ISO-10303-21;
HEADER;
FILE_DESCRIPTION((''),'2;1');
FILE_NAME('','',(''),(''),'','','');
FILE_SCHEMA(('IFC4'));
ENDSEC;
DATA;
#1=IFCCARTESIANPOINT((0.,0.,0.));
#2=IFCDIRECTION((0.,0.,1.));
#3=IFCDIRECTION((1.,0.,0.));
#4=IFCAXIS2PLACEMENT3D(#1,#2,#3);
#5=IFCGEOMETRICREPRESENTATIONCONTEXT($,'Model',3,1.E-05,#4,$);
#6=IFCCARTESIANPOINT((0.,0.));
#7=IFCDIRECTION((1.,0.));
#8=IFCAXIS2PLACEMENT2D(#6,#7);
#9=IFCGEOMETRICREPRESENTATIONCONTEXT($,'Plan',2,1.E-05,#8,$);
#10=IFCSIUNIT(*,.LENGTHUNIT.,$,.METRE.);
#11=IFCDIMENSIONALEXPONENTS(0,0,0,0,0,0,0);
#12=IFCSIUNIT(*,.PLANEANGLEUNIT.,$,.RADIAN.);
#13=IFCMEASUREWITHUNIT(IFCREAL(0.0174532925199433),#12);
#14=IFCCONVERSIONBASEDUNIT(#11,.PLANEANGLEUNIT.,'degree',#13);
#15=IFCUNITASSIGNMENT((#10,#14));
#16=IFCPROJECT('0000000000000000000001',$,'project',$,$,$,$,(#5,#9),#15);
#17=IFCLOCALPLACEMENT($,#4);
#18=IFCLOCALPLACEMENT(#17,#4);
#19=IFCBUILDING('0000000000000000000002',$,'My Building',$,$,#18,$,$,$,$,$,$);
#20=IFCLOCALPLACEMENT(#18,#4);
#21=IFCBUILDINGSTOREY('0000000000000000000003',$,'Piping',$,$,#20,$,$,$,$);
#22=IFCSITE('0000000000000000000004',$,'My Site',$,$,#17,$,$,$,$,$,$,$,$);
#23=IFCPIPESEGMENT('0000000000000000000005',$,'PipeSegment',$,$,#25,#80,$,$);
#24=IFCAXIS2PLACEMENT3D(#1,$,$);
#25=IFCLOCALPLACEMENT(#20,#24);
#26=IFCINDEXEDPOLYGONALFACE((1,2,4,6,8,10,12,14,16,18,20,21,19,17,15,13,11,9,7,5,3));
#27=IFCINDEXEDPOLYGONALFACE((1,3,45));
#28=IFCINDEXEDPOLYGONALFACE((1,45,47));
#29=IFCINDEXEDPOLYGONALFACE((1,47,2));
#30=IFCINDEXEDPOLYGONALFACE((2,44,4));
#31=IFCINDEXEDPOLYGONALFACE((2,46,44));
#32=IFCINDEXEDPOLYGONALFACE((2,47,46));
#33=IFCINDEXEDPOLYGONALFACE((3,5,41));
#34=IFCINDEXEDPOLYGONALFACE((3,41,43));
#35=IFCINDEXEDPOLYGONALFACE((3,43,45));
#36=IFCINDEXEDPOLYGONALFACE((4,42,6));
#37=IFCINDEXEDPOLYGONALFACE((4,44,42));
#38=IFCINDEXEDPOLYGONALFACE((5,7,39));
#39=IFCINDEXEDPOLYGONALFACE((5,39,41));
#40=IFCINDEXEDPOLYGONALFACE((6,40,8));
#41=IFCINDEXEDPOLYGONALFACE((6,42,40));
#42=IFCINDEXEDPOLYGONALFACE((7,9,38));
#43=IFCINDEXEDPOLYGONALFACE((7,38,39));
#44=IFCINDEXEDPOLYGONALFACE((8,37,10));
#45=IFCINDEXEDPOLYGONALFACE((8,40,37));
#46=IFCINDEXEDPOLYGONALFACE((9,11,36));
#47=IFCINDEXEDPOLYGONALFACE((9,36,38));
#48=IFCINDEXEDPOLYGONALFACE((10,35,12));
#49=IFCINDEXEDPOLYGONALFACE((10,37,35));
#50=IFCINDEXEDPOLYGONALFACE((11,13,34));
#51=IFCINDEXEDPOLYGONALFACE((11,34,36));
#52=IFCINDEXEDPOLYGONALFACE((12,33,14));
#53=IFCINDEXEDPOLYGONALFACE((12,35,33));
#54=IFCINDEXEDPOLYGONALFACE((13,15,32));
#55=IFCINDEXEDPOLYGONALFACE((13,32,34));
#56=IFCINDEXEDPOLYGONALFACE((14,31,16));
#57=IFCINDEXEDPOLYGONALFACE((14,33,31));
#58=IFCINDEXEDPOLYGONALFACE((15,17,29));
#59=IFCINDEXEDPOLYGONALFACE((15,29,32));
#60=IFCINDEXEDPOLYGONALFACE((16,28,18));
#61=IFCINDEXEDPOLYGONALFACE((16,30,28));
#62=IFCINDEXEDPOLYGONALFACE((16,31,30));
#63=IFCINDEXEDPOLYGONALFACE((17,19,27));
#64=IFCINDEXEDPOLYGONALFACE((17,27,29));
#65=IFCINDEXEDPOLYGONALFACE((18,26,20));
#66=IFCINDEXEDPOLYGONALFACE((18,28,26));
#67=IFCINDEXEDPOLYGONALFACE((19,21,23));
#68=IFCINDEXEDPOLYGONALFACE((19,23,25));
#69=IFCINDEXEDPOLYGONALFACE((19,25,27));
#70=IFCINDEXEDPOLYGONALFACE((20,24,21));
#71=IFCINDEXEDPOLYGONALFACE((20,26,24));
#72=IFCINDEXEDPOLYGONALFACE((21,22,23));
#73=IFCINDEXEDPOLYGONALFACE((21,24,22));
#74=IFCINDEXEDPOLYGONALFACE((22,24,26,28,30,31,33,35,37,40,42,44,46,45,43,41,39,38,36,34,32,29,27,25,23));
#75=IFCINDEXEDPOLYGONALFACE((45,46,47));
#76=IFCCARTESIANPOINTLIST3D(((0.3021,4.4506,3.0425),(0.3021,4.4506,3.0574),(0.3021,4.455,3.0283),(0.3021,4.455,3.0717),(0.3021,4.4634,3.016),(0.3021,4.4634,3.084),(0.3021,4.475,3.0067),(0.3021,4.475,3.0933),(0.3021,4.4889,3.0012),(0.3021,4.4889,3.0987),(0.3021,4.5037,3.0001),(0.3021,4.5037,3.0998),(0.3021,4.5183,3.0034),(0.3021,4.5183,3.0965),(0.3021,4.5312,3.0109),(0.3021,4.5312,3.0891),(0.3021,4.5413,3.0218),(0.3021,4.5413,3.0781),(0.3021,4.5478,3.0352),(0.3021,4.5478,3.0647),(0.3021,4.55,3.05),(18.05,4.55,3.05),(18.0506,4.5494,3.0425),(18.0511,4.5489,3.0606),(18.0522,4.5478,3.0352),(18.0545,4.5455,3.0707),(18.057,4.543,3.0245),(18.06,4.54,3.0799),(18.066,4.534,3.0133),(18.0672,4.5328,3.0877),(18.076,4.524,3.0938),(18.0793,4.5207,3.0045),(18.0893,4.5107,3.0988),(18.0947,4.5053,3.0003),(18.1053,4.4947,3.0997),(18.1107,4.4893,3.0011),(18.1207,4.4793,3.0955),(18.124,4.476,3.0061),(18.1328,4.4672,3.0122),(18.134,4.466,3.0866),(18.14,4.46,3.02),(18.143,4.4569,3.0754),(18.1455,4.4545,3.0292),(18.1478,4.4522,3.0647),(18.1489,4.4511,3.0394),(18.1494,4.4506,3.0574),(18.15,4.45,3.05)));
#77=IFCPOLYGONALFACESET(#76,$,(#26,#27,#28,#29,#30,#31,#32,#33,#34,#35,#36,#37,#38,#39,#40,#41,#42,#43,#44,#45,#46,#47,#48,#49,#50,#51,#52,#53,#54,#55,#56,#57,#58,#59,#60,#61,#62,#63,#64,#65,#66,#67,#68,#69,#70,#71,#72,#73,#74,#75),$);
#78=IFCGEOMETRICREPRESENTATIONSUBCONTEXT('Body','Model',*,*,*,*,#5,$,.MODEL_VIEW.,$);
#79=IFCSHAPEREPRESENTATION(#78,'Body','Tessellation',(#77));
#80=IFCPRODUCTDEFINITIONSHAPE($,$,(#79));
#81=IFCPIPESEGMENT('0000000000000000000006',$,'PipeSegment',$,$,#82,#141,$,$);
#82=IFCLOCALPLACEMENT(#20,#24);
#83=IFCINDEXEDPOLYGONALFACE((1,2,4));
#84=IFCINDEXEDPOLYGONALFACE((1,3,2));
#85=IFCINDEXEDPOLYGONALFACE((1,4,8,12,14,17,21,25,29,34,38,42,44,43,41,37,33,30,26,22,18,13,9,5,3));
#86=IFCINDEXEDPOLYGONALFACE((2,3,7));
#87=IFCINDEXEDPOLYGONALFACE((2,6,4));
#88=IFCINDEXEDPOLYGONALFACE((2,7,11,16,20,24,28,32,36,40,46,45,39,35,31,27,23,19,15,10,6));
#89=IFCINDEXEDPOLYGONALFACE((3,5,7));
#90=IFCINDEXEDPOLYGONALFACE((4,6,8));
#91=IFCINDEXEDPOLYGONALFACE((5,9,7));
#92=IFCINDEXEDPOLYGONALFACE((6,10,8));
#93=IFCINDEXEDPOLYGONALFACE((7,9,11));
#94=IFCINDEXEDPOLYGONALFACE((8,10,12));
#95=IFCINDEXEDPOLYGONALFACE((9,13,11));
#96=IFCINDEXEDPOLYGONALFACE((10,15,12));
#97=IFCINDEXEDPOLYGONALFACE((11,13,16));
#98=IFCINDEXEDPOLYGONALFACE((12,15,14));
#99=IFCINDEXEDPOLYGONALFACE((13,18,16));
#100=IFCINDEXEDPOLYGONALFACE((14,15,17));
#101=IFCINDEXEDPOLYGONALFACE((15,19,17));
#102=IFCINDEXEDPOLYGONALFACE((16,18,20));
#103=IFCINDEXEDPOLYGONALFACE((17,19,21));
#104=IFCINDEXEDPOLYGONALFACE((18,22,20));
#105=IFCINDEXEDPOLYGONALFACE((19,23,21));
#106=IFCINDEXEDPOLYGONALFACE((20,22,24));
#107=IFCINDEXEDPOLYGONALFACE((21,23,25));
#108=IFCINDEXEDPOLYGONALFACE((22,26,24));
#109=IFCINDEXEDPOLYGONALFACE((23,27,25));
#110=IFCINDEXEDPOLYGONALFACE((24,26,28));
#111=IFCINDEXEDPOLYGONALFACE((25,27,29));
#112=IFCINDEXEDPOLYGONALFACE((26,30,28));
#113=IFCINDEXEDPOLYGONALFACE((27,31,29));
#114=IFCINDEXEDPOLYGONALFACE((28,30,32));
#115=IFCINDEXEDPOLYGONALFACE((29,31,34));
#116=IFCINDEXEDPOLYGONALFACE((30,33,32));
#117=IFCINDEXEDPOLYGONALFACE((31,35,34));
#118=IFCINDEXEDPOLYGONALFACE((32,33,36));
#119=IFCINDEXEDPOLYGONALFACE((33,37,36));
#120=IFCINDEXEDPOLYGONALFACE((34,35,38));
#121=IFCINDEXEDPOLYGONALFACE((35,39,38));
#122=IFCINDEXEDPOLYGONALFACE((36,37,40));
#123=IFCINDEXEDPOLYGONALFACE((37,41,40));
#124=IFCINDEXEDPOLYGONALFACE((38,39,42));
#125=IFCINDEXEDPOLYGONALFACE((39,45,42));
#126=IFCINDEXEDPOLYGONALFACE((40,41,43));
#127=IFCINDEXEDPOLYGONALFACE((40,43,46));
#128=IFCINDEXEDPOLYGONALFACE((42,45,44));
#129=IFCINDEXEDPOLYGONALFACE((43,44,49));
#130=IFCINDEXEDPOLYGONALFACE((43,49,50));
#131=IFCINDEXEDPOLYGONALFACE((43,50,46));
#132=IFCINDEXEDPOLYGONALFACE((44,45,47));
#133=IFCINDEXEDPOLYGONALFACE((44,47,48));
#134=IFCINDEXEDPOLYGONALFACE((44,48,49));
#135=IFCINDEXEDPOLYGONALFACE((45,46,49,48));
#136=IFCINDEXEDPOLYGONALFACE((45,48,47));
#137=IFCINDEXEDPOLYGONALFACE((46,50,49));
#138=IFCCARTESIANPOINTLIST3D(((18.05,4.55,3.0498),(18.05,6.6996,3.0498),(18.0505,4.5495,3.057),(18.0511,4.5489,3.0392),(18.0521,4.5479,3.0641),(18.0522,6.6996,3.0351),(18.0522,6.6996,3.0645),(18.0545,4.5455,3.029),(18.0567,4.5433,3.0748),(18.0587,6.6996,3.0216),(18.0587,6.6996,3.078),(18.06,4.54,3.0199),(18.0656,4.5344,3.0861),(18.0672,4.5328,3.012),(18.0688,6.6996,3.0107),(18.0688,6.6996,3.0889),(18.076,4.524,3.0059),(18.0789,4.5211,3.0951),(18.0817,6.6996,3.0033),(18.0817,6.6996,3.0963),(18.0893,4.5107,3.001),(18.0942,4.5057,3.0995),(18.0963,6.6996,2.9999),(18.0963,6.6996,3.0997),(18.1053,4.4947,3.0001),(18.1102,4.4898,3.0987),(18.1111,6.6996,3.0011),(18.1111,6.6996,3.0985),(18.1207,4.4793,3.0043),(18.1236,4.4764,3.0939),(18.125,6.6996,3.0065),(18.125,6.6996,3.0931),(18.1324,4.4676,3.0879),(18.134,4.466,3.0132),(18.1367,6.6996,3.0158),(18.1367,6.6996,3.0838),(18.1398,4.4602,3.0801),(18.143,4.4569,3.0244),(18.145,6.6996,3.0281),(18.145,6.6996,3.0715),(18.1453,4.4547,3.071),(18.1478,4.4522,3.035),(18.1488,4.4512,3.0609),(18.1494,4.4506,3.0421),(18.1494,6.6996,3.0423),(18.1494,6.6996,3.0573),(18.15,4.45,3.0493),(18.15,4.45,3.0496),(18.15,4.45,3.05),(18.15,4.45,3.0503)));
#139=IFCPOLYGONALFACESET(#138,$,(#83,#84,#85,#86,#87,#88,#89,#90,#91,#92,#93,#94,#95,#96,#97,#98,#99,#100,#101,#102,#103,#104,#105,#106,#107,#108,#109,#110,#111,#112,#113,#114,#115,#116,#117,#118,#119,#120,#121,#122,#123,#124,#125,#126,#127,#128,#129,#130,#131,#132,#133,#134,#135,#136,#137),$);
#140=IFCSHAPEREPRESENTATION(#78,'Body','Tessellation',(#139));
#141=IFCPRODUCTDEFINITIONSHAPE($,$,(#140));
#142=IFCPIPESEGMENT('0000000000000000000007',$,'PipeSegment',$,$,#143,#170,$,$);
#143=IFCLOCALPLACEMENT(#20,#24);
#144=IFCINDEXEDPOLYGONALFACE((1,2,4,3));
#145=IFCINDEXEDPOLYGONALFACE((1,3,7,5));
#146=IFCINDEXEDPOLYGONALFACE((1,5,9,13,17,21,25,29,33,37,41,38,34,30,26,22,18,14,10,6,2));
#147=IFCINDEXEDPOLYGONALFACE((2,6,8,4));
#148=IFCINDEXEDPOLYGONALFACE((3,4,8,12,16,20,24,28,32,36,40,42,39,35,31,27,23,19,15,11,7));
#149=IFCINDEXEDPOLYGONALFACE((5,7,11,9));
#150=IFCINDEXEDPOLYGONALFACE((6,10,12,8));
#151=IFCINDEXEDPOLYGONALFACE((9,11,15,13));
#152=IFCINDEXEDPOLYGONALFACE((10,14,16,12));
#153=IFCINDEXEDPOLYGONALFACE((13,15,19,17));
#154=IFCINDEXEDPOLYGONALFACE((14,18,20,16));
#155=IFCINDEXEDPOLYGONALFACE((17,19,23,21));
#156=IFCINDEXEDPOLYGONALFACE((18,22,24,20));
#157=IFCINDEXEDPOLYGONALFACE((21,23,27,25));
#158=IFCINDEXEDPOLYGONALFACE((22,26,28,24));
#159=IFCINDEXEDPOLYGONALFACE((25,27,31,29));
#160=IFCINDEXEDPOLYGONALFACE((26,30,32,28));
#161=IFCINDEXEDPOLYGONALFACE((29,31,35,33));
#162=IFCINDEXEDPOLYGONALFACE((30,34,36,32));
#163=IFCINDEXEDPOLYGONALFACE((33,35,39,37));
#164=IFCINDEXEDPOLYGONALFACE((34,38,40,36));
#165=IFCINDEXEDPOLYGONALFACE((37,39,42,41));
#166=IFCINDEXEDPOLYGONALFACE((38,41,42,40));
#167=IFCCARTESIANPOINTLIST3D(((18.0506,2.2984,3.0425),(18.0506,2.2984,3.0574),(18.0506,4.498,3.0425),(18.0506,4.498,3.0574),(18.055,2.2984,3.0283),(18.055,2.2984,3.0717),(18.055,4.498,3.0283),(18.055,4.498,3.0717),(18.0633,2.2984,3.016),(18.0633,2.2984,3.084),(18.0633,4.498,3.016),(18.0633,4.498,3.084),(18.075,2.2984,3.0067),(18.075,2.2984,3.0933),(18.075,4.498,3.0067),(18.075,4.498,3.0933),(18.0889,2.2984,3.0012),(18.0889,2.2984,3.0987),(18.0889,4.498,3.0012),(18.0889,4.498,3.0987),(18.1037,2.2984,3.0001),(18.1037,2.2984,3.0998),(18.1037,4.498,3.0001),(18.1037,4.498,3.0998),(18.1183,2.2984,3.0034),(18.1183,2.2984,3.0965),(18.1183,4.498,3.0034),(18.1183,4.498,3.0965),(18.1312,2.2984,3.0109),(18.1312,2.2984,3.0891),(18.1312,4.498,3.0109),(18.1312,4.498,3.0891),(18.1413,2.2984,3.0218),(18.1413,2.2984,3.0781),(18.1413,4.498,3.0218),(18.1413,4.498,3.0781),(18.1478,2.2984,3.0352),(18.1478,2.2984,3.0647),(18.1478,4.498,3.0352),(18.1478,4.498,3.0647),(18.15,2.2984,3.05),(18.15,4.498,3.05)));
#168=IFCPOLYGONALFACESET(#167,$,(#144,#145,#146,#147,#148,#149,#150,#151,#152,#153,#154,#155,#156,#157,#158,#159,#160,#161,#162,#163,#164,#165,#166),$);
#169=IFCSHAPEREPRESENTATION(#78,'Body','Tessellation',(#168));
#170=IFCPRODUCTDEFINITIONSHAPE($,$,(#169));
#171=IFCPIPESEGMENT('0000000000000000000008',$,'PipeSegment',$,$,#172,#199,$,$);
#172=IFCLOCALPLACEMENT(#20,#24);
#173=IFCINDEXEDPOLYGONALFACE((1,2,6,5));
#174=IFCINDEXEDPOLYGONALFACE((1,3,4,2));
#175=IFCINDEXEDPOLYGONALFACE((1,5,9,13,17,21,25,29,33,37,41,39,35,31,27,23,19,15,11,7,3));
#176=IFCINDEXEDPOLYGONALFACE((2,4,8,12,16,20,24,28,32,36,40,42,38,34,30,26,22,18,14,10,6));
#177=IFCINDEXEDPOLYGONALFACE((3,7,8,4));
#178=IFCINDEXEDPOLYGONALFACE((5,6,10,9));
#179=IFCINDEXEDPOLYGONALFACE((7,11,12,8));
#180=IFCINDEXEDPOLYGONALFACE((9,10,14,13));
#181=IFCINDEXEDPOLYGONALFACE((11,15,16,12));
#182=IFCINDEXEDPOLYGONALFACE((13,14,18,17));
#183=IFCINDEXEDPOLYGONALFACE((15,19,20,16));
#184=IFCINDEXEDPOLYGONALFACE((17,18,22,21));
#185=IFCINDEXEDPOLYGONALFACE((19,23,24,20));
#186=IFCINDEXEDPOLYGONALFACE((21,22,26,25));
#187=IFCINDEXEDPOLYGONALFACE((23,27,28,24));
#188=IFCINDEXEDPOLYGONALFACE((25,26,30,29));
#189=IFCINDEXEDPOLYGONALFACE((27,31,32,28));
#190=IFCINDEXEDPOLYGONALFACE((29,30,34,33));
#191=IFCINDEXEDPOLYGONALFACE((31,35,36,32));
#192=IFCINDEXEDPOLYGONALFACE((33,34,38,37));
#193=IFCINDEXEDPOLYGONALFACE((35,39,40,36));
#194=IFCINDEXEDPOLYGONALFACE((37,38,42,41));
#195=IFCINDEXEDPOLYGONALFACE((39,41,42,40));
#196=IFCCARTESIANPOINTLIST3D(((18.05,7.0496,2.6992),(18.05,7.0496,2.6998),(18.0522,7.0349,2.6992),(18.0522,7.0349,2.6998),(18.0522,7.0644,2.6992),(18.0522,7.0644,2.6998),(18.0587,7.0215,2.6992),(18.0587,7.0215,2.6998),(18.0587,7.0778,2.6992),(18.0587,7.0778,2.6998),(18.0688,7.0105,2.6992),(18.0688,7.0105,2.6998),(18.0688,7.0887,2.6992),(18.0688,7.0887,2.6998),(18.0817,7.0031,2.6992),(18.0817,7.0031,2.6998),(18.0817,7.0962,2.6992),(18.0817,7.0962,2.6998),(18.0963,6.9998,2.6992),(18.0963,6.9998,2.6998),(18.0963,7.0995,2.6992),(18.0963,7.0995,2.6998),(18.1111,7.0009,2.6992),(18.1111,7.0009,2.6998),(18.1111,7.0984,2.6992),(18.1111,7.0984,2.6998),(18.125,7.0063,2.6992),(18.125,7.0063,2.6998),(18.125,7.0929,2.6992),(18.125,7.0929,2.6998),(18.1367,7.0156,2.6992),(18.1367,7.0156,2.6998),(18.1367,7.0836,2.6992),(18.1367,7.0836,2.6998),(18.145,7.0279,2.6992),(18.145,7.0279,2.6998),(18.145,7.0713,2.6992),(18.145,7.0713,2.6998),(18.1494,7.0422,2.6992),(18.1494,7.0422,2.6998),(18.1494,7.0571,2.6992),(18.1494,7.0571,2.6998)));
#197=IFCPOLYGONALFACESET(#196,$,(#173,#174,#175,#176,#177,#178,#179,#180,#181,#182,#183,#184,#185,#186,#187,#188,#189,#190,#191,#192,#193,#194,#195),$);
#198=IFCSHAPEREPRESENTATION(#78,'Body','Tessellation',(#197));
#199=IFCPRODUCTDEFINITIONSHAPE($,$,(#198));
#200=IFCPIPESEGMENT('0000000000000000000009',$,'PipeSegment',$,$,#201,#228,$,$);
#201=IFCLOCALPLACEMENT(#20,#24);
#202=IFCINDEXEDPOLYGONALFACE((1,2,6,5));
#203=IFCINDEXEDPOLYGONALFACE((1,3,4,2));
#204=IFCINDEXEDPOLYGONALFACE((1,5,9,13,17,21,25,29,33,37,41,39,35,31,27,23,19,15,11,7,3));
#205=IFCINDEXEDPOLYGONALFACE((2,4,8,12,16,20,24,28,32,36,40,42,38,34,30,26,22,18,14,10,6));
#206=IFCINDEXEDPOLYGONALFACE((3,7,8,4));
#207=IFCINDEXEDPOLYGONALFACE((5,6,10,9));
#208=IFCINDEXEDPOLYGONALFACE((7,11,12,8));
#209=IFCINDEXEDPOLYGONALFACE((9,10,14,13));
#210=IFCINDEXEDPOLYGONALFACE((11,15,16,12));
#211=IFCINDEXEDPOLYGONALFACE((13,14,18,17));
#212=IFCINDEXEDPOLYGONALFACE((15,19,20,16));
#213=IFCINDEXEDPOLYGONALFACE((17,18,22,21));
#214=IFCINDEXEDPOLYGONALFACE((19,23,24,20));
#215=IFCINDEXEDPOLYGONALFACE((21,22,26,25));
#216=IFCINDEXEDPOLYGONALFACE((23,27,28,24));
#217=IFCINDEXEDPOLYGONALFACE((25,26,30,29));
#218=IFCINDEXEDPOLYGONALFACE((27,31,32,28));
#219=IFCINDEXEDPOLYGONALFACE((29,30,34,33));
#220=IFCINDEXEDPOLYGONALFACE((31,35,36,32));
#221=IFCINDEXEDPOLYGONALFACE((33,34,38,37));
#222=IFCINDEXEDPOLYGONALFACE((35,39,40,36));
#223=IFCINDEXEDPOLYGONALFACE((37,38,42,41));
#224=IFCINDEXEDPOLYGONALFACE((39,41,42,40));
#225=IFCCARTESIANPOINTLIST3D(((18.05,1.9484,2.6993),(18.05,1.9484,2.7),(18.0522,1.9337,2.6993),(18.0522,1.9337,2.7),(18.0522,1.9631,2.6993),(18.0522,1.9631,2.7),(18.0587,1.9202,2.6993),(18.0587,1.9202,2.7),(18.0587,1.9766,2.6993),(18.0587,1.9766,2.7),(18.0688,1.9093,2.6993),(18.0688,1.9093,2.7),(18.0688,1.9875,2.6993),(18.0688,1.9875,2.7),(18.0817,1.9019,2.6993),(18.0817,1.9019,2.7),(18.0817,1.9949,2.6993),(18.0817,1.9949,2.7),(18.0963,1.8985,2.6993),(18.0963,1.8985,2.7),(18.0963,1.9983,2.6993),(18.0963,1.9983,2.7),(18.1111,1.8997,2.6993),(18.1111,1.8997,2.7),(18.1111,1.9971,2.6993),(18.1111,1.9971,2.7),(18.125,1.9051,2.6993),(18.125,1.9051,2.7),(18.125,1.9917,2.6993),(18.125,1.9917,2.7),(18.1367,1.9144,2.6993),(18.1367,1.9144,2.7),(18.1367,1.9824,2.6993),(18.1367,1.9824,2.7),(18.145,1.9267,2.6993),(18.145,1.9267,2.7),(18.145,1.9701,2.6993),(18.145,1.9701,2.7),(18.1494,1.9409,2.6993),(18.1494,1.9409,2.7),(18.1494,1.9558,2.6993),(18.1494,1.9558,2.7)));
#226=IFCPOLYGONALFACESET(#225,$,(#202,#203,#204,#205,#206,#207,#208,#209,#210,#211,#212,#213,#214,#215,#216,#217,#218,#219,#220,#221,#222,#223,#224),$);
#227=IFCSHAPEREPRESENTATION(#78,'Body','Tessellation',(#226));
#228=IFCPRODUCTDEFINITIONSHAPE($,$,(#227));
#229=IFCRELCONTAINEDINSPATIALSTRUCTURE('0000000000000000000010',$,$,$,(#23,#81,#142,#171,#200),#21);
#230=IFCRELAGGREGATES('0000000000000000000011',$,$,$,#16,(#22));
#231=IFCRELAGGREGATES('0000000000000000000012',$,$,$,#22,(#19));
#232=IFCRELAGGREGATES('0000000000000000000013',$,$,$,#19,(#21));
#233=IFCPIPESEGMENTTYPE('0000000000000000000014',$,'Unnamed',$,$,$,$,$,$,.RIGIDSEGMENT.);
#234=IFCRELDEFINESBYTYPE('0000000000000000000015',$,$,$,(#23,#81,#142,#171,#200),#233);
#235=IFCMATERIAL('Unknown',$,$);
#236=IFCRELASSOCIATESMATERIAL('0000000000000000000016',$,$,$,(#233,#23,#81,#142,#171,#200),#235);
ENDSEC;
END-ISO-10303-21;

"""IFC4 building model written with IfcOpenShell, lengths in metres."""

from ifc_helpers import new_model, entity, si_unit, converted_unit, frame, origin_with_axes, origin_2d_with_axis, place, context, subcontext, project, spatial, circle, extrude, clip, halfspace, material, material_profile, profile_set, profile_usage, type_object, element, save


model = new_model("IFC4")

# Units and contexts
model_context = context("Model", 3, precision=1e-05, world=origin_with_axes())
plan_context = context("Plan", 2, precision=1e-05, world=origin_2d_with_axis())
body_context = subcontext(model_context, "Body", "Model", "MODEL_VIEW")
ifc_project = project(units=[si_unit("LENGTHUNIT", "METRE"), converted_unit("PLANEANGLEUNIT", "degree", entity("IfcReal", 0.0174532925199433), si_unit("PLANEANGLEUNIT", "RADIAN"), dimensions=[0, 0, 0, 0, 0, 0, 0])], contexts=[model_context, plan_context])

# Site, building, storey
site_placement = place(None, origin_with_axes())
site = spatial("IfcSite", under=ifc_project, at=site_placement, Name="My Site")
building_placement = place(site_placement, origin_with_axes())
building = spatial("IfcBuilding", under=site, at=building_placement, Name="My Building")
storey_placement = place(building_placement, origin_with_axes())
storey = spatial("IfcBuildingStorey", under=building, at=storey_placement, Name="Piping")

# Pipe segments
ifc_material = material(Name="Unknown")
ifc_material_profile_1 = material_profile(ifc_material, circle(Radius=0.05))
ifc_profile_set_1 = profile_set([ifc_material_profile_1])
ifc_profile_usage_1 = profile_usage(ifc_profile_set_1, cardinal=5)
pipe_segment_type = type_object("IfcPipeSegmentType", Name="Unnamed", PredefinedType="RIGIDSEGMENT", material=ifc_profile_set_1)
pipe_segment_1_placement = place(storey_placement, frame((0.3021, 4.5, 3.05), z_axis=(1.0, -0.000001, 0.000001), x_axis=(0.000001, 1.0, 0.0)))
element("IfcPipeSegment", 1, at=pipe_segment_1_placement, inside=storey, type_object=pipe_segment_type, material=ifc_profile_usage_1, Name="PipeSegment", context=body_context, shape_type="Clipping", body=[
    clip(extrude(circle(Radius=0.05), origin_with_axes(), (0.0, 0.0, 1.0), 17.8479), halfspace(frame((-0.05, -3.05, 17.8479), z_axis=(0.7071, 0.0, 0.707113), x_axis=(-0.000001, -1.0, 0.0)), False)),
])
ifc_profile_usage_2 = profile_usage(ifc_profile_set_1, cardinal=5)
pipe_segment_2_placement = place(storey_placement, frame((18.1, 4.45, 3.0498), z_axis=(0.0, 1.0, 0.0), x_axis=(-1.0, 0.0, 0.0)))
element("IfcPipeSegment", 2, at=pipe_segment_2_placement, inside=storey, type_object=pipe_segment_type, material=ifc_profile_usage_2, Name="PipeSegment", context=body_context, shape_type="Clipping", body=[
    clip(extrude(circle(Radius=0.05), origin_with_axes(), (0.0, 0.0, 1.0), 2.2496), halfspace(frame((-0.05, -3.0, 0.0), z_axis=(0.707114, 0.0, -0.7071), x_axis=(0.000001, -1.0, 0.0)), False)),
])
ifc_profile_usage_3 = profile_usage(ifc_profile_set_1, cardinal=5)
pipe_segment_3_placement = place(storey_placement, frame((18.1, 4.498, 3.05), z_axis=(0.0, -1.0, -0.000001), x_axis=(1.0, 0.0, 0.0)))
element("IfcPipeSegment", 3, at=pipe_segment_3_placement, inside=storey, type_object=pipe_segment_type, material=ifc_profile_usage_3, Name="PipeSegment", context=body_context, shape_type="SweptSolid", body=[
    extrude(circle(Radius=0.05), origin_with_axes(), (0.0, 0.0, 1.0), 2.1996),
])
ifc_profile_usage_4 = profile_usage(ifc_profile_set_1, cardinal=5)
pipe_segment_4_placement = place(storey_placement, frame((18.1, 7.0496, 2.6998), z_axis=(0.0, 0.0, -1.0), x_axis=(-1.0, 0.0, 0.0)))
element("IfcPipeSegment", 4, at=pipe_segment_4_placement, inside=storey, type_object=pipe_segment_type, material=ifc_profile_usage_4, Name="PipeSegment", context=body_context, shape_type="SweptSolid", body=[
    extrude(circle(Radius=0.05), origin_with_axes(), (0.0, 0.0, 1.0), 0.0006),
])
ifc_profile_usage_5 = profile_usage(ifc_profile_set_1, cardinal=5)
pipe_segment_5_placement = place(storey_placement, frame((18.1, 1.9484, 2.7), z_axis=(0.0, 0.0, -1.0), x_axis=(-1.0, 0.0, 0.0)))
element("IfcPipeSegment", 5, at=pipe_segment_5_placement, inside=storey, type_object=pipe_segment_type, material=ifc_profile_usage_5, Name="PipeSegment", context=body_context, shape_type="SweptSolid", body=[
    extrude(circle(Radius=0.05), origin_with_axes(), (0.0, 0.0, 1.0), 0.0006),
])

save(model, "model.ifc")
